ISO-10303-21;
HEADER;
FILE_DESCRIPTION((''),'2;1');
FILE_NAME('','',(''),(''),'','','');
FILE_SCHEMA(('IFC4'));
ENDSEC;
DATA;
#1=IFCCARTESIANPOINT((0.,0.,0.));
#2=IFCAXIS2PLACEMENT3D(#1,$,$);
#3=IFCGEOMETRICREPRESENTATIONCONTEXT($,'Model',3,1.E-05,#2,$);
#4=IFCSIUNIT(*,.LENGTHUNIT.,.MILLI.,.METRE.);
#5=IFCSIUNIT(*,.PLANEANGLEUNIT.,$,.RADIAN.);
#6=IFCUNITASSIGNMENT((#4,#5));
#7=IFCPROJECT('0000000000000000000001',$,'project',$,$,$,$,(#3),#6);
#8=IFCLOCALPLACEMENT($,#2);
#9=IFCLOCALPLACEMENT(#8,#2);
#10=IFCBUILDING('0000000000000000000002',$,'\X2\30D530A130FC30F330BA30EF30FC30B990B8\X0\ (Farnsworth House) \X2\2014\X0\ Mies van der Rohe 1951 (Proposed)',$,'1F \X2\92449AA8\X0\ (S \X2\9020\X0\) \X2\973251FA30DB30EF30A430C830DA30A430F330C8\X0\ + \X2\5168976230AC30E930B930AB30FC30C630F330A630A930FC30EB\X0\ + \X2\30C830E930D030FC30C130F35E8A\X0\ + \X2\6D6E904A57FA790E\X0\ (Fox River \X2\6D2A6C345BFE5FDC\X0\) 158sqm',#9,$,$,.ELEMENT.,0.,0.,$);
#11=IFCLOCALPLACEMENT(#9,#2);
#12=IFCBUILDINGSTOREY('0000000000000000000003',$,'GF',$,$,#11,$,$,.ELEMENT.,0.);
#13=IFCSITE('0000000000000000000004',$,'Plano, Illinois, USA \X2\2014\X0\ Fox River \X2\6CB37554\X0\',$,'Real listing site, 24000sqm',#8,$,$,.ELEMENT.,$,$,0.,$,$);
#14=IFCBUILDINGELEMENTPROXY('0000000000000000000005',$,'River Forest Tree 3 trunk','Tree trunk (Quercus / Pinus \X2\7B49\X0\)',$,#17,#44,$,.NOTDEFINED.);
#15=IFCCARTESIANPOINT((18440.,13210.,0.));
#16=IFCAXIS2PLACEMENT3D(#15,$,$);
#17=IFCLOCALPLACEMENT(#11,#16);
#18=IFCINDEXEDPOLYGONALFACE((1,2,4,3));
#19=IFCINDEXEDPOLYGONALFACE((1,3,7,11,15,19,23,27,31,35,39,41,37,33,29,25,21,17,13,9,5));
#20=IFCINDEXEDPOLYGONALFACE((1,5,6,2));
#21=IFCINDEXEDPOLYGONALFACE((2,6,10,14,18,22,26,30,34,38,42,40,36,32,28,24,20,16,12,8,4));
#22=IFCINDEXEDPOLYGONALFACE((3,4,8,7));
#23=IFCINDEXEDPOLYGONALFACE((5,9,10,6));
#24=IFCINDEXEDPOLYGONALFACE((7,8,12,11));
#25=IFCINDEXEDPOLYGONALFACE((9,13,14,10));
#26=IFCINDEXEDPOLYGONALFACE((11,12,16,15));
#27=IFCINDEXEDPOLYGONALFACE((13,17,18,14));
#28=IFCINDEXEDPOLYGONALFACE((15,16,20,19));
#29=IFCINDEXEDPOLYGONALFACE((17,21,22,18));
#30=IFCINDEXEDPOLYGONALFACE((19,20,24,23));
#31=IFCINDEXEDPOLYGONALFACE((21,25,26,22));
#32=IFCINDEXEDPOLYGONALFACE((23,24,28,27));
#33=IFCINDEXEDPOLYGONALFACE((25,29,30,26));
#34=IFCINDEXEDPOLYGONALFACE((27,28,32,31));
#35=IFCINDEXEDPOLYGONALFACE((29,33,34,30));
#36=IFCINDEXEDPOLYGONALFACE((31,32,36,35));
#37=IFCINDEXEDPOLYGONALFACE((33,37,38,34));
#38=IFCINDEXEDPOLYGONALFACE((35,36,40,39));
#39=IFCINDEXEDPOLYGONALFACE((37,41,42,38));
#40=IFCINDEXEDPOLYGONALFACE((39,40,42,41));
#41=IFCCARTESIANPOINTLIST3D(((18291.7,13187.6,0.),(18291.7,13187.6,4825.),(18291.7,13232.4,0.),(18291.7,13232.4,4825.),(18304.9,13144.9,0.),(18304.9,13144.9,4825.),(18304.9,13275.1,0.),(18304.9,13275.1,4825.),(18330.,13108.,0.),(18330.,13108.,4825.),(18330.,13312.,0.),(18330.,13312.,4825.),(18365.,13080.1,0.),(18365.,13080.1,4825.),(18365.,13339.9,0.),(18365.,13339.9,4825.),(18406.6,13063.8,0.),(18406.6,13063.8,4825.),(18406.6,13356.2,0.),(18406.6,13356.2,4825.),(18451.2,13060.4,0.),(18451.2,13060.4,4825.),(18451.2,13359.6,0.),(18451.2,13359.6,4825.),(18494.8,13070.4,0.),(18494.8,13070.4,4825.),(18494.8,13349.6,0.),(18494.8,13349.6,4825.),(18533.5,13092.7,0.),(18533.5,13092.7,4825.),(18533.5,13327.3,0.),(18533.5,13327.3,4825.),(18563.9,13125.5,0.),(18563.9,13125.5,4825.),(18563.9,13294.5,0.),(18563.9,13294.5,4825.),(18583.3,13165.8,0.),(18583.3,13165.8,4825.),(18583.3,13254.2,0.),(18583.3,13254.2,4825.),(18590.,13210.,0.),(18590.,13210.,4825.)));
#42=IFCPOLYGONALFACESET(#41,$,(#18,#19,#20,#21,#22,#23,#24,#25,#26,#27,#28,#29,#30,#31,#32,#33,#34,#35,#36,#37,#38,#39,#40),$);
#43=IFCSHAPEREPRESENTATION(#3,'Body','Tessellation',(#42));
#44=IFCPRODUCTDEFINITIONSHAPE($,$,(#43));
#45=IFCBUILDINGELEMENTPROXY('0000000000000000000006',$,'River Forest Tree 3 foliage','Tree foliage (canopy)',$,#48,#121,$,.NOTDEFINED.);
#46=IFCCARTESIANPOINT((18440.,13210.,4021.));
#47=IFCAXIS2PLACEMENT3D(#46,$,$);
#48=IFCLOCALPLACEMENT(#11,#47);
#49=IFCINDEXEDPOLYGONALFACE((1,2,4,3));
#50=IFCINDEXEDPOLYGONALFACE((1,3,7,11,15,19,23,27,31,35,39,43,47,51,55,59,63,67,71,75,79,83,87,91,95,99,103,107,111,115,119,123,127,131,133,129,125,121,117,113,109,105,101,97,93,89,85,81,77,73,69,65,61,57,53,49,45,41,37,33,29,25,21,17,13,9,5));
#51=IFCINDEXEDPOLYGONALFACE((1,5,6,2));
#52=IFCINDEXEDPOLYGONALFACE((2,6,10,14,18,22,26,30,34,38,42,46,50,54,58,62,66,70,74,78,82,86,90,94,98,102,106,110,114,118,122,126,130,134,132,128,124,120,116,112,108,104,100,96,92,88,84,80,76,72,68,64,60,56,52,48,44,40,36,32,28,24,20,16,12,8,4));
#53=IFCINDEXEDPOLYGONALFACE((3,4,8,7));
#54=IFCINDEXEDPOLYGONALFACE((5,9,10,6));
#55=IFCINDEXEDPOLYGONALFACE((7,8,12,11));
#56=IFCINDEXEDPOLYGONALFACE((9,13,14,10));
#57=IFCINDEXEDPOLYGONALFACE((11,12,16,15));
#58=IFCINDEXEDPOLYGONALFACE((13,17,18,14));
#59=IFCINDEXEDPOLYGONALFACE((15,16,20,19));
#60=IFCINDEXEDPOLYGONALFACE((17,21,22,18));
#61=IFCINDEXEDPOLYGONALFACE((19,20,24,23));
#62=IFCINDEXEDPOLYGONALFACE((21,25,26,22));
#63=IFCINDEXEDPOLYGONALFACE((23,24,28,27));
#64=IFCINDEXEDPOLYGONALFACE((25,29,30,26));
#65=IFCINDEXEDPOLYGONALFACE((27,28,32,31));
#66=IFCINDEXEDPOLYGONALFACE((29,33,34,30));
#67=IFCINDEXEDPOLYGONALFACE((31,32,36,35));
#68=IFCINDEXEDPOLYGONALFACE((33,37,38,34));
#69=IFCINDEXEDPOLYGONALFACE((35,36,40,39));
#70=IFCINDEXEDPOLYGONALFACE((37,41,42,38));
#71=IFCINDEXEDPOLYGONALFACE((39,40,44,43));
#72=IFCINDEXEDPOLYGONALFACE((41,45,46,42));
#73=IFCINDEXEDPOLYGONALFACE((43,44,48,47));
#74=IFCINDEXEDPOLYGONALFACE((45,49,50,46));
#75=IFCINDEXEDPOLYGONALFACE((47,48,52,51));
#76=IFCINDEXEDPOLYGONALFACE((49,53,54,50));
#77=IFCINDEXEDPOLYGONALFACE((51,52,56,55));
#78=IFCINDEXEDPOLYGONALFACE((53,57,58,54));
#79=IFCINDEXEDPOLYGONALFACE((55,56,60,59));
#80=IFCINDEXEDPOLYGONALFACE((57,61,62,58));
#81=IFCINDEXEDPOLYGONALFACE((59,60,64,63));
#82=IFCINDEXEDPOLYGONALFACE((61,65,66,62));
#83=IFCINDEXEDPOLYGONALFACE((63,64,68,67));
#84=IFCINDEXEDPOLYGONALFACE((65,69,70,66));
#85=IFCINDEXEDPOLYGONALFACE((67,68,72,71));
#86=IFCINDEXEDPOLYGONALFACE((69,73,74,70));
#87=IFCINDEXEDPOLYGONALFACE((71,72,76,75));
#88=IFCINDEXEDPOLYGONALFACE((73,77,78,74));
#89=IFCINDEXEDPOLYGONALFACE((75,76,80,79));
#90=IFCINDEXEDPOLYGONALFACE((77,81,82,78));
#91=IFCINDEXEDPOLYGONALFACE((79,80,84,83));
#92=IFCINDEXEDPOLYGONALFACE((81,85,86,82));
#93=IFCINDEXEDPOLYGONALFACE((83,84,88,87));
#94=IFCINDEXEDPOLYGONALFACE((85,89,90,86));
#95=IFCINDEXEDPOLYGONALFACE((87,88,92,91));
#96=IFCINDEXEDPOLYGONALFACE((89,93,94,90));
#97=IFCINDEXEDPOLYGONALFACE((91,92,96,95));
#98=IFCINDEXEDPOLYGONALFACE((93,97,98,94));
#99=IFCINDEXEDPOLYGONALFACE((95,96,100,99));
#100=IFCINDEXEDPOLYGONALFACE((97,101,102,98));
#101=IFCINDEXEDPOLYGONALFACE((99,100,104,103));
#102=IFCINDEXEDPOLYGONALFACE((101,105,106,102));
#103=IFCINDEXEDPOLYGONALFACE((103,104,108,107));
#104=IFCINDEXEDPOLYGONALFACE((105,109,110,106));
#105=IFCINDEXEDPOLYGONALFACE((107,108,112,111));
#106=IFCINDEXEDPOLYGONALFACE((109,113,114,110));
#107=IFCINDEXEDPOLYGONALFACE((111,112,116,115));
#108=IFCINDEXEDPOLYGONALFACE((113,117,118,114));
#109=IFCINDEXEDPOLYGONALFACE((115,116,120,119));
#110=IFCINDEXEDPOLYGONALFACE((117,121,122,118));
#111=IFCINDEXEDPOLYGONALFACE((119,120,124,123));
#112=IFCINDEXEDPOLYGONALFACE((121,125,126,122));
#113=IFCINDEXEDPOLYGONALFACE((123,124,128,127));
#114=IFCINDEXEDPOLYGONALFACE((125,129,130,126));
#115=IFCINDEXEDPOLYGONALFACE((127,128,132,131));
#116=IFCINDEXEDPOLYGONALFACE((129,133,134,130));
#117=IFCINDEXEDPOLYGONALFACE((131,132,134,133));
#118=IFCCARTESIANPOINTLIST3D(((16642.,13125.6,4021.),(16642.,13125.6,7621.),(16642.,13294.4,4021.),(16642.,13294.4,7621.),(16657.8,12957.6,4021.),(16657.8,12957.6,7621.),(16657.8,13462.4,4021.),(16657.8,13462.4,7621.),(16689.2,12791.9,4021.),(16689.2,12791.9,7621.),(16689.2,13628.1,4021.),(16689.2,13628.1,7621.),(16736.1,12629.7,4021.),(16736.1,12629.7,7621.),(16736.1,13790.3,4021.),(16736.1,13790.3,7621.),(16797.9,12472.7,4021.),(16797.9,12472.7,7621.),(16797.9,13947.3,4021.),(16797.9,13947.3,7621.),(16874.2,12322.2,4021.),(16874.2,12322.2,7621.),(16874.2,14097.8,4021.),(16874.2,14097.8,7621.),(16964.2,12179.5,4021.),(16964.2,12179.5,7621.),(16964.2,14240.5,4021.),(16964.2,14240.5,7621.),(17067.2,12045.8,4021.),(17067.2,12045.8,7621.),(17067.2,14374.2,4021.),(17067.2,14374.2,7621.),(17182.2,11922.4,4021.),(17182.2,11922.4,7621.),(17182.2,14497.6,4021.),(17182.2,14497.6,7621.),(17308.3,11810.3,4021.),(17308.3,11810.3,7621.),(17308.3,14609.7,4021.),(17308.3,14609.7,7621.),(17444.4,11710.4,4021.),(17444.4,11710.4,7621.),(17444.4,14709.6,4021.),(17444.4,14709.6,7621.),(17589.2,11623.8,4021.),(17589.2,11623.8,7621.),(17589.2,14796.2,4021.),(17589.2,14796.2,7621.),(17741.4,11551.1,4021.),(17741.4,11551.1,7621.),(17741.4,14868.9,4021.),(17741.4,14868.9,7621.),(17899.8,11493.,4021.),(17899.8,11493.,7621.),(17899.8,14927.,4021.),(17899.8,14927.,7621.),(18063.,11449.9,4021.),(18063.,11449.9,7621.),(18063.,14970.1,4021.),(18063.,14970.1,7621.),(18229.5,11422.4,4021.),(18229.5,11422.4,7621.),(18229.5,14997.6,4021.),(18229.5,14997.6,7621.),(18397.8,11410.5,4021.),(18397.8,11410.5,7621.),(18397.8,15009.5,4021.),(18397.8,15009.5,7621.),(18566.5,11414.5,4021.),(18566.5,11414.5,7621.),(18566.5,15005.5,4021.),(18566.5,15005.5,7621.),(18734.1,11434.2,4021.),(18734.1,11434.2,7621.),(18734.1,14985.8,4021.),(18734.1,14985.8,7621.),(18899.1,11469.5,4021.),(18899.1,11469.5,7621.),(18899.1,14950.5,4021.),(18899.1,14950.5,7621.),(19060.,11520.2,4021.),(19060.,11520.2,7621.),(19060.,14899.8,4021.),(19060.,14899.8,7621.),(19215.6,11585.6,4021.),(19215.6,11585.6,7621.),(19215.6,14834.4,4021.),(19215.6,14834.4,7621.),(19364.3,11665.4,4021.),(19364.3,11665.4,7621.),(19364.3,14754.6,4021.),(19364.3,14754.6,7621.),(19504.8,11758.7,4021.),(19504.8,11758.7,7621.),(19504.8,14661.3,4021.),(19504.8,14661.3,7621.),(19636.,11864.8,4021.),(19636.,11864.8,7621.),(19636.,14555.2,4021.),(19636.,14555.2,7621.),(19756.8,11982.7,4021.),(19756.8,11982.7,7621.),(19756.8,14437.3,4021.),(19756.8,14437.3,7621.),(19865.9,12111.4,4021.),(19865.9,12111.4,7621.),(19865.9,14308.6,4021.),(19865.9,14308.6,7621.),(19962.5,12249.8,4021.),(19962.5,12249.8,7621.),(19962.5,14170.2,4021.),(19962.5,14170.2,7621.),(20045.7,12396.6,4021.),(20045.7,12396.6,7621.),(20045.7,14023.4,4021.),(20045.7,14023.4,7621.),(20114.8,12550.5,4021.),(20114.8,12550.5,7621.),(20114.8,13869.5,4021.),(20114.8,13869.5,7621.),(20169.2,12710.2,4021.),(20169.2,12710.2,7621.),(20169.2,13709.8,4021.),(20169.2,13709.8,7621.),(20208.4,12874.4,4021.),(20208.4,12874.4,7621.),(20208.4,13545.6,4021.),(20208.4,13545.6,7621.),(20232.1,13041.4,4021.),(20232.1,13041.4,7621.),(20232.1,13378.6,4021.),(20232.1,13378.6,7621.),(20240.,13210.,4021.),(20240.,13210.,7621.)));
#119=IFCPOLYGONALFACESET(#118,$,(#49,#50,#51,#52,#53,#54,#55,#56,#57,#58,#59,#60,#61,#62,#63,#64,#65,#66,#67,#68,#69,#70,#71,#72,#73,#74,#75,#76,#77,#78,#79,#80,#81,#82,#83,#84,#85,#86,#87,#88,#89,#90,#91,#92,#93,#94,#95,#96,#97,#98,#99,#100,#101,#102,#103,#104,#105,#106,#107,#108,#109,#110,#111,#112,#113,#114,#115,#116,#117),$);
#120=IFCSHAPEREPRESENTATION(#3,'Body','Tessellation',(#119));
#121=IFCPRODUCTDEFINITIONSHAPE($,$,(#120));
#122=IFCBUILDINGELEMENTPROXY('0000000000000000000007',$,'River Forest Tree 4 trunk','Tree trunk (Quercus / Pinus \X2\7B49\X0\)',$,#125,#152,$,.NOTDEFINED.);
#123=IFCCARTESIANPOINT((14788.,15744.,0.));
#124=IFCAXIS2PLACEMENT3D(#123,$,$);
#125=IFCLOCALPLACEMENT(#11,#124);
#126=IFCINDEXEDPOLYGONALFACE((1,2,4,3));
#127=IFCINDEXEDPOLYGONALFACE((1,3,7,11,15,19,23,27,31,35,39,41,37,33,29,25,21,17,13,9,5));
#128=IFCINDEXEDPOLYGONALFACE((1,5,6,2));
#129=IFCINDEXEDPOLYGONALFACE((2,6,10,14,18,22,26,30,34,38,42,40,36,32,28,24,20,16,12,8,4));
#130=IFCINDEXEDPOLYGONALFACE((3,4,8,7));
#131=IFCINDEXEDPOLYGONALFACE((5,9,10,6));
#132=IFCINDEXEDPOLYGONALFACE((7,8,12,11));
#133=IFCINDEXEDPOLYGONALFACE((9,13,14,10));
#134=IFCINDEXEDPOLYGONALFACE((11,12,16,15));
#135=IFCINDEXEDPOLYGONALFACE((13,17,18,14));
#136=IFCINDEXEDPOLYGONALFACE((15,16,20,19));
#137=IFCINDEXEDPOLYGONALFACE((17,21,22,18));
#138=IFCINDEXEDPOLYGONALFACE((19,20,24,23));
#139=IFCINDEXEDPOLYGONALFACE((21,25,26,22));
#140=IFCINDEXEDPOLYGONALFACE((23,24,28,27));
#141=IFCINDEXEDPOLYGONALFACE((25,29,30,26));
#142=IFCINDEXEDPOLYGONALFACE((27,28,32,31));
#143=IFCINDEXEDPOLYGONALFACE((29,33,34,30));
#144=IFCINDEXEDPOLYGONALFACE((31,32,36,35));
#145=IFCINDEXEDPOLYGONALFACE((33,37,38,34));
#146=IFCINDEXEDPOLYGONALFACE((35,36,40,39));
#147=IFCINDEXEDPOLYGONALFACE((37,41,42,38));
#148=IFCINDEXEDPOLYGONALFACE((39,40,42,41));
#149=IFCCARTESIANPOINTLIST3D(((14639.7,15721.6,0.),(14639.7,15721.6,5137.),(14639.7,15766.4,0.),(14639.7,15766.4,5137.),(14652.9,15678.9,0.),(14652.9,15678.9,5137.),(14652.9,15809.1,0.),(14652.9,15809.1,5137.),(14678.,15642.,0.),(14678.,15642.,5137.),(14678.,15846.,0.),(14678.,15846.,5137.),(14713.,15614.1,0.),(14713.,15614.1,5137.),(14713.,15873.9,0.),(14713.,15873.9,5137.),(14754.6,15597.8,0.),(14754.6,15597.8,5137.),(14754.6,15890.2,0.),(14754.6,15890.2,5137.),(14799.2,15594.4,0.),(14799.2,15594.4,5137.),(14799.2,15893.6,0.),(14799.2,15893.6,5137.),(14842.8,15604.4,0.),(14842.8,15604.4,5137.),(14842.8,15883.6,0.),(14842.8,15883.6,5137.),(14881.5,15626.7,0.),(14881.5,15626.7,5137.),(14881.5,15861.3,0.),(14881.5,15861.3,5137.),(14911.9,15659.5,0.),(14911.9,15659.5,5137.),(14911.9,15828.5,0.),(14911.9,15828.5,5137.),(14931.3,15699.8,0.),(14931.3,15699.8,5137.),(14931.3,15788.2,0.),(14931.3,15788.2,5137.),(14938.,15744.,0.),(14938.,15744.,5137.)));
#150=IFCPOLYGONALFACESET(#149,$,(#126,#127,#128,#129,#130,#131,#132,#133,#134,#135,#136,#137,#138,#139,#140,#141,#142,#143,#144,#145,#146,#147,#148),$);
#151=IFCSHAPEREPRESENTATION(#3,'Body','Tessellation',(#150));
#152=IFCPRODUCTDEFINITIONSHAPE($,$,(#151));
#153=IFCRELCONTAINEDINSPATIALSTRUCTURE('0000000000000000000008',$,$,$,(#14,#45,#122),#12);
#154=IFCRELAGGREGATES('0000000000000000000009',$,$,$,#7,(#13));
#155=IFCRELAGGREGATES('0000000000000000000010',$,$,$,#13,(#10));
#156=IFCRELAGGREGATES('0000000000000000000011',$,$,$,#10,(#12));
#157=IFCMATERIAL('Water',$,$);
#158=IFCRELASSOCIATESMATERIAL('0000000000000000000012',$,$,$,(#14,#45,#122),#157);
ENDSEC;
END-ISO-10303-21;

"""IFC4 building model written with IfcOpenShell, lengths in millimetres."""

from ifc_helpers import new_model, si_unit, frame, origin, origin_2d, place, context, project, spatial, circle, extrude, material, element, save


model = new_model("IFC4")

# Units and contexts
model_context = context("Model", 3, precision=1e-05, world=origin())
ifc_project = project(units=[si_unit("LENGTHUNIT", "METRE", prefix="MILLI"), si_unit("PLANEANGLEUNIT", "RADIAN")], contexts=[model_context])

# Site, building, storey
site_placement = place(None, origin())
site = spatial("IfcSite", under=ifc_project, at=site_placement, Name="Plano, Illinois, USA — Fox River 河畔", ObjectType="Real listing site, 24000sqm", CompositionType="ELEMENT", RefElevation=0.0)
building_placement = place(site_placement, origin())
building = spatial("IfcBuilding", under=site, at=building_placement, Name="ファーンズワース邸 (Farnsworth House) — Mies van der Rohe 1951 (Proposed)", ObjectType="1F 鉄骨 (S 造) 露出ホワイトペイント + 全面ガラスカーテンウォール + トラバーチン床 + 浮遊基礎 (Fox River 洪水対応) 158sqm", CompositionType="ELEMENT", ElevationOfRefHeight=0.0, ElevationOfTerrain=0.0)
storey_placement = place(building_placement, origin())
storey = spatial("IfcBuildingStorey", under=building, at=storey_placement, Name="GF", CompositionType="ELEMENT", Elevation=0.0)

# Building element proxies
ifc_material_1 = material(Name="Water")
proxy_1_placement = place(storey_placement, frame((18440.0, 13210.0, 0.0)))
element("IfcBuildingElementProxy", 1, at=proxy_1_placement, inside=storey, material=ifc_material_1, Name="River Forest Tree 3 trunk", Description="Tree trunk (Quercus / Pinus 等)", PredefinedType="NOTDEFINED", context=model_context, shape_type="SweptSolid", body=[
    extrude(circle(Radius=150.0, at=origin_2d()), frame((18440.0, 13210.0, 0.0)), (0.0, 0.0, 1.0), 4825.0),
])
proxy_2_placement = place(storey_placement, frame((18440.0, 13210.0, 4021.0)))
element("IfcBuildingElementProxy", 2, at=proxy_2_placement, inside=storey, material=ifc_material_1, Name="River Forest Tree 3 foliage", Description="Tree foliage (canopy)", PredefinedType="NOTDEFINED", context=model_context, shape_type="SweptSolid", body=[
    extrude(circle(Radius=1800.0, at=origin_2d()), frame((18440.0, 13210.0, 4021.0)), (0.0, 0.0, 1.0), 3600.0),
])
proxy_3_placement = place(storey_placement, frame((14788.0, 15744.0, 0.0)))
element("IfcBuildingElementProxy", 3, at=proxy_3_placement, inside=storey, material=ifc_material_1, Name="River Forest Tree 4 trunk", Description="Tree trunk (Quercus / Pinus 等)", PredefinedType="NOTDEFINED", context=model_context, shape_type="SweptSolid", body=[
    extrude(circle(Radius=150.0, at=origin_2d()), frame((14788.0, 15744.0, 0.0)), (0.0, 0.0, 1.0), 5137.0),
])

save(model, "model.ifc")
